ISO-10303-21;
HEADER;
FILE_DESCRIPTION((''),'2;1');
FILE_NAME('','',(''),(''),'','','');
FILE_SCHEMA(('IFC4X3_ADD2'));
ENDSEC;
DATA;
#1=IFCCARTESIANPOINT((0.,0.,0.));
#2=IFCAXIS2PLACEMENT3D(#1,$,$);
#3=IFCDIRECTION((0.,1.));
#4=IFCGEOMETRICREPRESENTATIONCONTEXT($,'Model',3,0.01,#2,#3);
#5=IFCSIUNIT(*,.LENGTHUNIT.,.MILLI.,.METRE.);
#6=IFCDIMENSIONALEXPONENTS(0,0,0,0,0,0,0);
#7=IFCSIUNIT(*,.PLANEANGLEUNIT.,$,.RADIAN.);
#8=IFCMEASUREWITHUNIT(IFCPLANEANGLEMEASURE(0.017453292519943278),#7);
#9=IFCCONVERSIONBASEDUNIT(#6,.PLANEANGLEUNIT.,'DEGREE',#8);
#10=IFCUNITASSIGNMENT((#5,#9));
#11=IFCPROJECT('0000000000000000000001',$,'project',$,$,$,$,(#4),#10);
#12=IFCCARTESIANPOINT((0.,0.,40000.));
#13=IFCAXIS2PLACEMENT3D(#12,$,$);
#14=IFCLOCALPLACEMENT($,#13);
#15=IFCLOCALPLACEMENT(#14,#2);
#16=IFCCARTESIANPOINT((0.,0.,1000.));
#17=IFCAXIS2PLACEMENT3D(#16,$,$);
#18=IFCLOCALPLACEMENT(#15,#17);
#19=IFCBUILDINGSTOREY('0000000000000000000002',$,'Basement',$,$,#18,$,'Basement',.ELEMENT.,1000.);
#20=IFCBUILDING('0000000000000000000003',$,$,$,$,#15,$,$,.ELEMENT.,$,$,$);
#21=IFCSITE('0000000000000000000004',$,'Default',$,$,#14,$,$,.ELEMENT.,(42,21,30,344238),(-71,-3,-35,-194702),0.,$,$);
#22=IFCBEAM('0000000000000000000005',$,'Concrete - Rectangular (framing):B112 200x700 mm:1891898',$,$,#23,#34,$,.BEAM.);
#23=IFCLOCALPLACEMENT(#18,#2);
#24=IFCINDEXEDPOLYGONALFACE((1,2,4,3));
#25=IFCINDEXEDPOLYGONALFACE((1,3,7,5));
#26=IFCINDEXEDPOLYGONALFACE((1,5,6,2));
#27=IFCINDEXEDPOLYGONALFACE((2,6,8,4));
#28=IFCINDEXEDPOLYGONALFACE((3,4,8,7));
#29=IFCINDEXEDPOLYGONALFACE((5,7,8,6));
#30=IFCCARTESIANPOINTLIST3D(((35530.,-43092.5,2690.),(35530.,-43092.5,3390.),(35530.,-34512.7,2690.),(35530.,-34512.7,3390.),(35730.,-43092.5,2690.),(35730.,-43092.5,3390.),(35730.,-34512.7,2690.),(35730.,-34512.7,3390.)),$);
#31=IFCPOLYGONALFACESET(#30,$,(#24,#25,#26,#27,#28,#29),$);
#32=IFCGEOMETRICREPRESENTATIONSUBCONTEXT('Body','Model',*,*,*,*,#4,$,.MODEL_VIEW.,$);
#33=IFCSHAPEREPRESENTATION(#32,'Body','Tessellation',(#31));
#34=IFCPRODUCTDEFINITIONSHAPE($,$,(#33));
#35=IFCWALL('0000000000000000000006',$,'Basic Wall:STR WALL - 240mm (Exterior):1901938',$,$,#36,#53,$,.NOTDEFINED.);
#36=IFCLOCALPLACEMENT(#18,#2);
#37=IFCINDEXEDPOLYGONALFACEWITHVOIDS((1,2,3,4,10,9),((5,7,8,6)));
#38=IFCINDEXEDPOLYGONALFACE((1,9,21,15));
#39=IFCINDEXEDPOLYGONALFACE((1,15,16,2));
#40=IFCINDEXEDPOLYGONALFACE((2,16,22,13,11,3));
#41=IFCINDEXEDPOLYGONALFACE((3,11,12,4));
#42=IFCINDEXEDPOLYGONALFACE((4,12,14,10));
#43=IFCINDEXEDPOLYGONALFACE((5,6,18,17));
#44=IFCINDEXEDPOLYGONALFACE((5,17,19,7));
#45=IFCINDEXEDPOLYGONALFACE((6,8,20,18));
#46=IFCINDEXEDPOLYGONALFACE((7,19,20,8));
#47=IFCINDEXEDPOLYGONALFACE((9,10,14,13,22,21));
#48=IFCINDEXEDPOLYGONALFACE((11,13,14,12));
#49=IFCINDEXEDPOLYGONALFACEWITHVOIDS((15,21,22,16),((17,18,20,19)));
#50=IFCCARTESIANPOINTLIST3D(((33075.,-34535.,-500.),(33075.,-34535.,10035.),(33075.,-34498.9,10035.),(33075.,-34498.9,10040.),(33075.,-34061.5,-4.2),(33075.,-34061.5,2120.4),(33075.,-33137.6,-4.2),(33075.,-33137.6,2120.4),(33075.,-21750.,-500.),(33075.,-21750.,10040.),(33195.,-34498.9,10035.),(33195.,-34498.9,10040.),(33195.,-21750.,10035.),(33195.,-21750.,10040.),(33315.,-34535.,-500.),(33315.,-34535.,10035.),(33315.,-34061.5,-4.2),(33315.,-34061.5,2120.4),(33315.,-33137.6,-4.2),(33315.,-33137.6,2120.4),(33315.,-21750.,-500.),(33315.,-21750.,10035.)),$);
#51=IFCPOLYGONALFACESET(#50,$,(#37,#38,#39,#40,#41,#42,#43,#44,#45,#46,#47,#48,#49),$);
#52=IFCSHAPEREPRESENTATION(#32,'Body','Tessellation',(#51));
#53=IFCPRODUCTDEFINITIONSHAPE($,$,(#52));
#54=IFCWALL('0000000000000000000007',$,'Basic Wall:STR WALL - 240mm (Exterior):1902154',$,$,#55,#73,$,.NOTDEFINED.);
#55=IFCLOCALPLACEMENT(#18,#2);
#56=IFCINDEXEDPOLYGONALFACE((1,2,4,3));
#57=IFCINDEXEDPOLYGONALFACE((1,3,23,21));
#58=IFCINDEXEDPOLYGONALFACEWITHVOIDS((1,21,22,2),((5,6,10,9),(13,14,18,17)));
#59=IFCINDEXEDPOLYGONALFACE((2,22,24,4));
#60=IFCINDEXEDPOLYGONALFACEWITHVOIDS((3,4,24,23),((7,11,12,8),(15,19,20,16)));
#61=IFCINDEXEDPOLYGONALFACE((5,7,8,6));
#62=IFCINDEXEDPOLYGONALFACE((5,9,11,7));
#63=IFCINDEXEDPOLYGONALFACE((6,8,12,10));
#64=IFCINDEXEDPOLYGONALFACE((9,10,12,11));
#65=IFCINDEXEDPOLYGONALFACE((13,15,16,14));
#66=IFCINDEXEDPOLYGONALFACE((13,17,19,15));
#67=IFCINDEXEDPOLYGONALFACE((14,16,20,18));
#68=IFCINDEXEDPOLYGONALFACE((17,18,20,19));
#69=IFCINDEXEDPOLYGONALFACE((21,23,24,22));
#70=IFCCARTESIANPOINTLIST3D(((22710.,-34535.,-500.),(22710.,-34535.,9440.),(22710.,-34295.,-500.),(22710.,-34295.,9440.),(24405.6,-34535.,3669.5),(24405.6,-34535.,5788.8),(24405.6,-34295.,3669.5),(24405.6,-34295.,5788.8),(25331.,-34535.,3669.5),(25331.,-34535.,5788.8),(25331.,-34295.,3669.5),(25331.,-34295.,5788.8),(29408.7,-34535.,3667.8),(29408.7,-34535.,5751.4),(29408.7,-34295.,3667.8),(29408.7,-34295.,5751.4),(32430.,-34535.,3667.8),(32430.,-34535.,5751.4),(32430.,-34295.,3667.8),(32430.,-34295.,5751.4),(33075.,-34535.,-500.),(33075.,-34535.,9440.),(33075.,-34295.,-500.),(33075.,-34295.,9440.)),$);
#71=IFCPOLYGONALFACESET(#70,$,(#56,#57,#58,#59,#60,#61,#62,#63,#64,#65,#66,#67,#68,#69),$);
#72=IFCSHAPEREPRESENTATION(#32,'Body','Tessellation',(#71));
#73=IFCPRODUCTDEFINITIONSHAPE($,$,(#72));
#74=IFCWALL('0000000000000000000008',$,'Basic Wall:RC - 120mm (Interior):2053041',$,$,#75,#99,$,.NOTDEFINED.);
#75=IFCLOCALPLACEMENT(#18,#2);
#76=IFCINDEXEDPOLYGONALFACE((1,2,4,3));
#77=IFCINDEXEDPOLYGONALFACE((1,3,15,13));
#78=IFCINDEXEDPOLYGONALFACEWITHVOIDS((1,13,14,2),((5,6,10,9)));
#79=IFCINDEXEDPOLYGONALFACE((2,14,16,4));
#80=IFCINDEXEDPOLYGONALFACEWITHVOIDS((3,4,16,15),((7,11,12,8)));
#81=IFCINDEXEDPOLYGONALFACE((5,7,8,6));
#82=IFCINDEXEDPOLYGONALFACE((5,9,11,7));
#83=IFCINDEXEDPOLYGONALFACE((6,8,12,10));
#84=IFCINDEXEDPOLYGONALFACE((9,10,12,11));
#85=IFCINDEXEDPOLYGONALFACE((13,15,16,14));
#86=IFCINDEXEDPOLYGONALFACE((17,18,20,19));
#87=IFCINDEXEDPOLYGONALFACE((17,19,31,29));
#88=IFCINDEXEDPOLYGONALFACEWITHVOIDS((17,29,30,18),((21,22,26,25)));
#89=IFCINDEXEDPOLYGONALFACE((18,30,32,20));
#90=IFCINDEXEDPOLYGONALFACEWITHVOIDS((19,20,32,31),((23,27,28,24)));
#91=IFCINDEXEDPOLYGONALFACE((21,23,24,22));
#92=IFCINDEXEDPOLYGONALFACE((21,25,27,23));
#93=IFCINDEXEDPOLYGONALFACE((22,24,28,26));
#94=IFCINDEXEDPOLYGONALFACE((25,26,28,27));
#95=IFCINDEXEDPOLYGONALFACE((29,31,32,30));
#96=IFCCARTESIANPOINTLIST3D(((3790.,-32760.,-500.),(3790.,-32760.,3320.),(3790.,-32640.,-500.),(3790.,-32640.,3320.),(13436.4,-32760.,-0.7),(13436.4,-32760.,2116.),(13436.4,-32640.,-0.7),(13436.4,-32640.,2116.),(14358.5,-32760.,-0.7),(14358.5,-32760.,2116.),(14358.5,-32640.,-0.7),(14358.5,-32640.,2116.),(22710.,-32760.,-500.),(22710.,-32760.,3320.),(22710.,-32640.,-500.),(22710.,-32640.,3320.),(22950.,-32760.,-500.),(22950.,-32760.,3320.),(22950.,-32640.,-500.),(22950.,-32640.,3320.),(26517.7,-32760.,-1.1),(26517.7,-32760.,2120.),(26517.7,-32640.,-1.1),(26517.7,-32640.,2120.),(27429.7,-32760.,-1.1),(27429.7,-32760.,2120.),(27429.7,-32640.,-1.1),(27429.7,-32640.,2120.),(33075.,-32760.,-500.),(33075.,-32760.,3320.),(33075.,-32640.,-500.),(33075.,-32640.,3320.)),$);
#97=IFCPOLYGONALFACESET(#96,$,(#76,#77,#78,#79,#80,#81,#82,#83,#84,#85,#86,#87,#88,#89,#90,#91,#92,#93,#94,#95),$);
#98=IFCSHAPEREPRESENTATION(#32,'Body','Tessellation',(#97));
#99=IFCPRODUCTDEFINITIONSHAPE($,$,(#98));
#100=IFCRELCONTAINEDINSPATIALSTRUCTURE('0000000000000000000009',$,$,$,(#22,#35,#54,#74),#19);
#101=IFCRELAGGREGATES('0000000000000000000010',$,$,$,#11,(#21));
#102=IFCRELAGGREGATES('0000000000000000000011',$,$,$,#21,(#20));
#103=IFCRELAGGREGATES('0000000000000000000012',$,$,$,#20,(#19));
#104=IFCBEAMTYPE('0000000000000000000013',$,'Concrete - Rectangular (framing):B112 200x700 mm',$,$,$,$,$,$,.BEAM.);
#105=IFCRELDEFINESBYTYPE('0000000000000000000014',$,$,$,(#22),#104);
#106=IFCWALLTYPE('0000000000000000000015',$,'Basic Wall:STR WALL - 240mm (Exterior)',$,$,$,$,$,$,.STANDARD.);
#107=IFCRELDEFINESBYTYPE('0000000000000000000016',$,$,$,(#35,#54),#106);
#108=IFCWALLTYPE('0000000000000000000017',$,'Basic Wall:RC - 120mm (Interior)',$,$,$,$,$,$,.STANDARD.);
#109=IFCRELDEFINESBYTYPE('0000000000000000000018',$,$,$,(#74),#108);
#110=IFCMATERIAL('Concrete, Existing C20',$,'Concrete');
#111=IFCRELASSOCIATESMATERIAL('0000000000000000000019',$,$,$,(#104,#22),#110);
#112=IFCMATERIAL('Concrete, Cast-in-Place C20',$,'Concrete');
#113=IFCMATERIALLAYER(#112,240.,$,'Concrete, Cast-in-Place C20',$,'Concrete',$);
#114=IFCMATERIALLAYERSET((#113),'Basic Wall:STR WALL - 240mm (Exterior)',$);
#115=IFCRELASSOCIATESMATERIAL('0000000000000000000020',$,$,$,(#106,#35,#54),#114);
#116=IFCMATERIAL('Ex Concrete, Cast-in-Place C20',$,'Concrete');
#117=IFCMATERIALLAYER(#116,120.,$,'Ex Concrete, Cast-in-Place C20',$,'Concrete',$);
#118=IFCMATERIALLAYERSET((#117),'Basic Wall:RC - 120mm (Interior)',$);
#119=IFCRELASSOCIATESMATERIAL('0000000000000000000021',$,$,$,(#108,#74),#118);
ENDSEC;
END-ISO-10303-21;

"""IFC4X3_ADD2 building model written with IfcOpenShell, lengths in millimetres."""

from ifc_helpers import new_model, entity, si_unit, converted_unit, direction, frame, frame_2d, origin, origin_2d_with_axis, place, context, subcontext, project, spatial, polyline, rectangle, extrude, clip, bounded_halfspace, source, transform, mapped, material, layer, layer_set, material_profile, profile_set, profile_usage, type_object, type_shapes, element, save


model = new_model("IFC4X3_ADD2")

# Units and contexts
model_context = context("Model", 3, precision=0.01, world=origin(), true_north=direction((0.0, 1.0)))
body_context = subcontext(model_context, "Body", "Model", "MODEL_VIEW")
ifc_project = project(units=[si_unit("LENGTHUNIT", "METRE", prefix="MILLI"), converted_unit("PLANEANGLEUNIT", "DEGREE", entity("IfcPlaneAngleMeasure", 0.017453292519943278), si_unit("PLANEANGLEUNIT", "RADIAN"), dimensions=[0, 0, 0, 0, 0, 0, 0])], contexts=[model_context])

# Site, building, storey
site_placement = place(None, frame((0.0, 0.0, 40000.0)))
site = spatial("IfcSite", under=ifc_project, at=site_placement, Name="Default", CompositionType="ELEMENT", RefLatitude=(42, 21, 30, 344238), RefLongitude=(-71, -3, -35, -194702), RefElevation=0.0)
building_placement = place(site_placement, origin())
building = spatial("IfcBuilding", under=site, at=building_placement, CompositionType="ELEMENT")
storey_placement = place(building_placement, frame((0.0, 0.0, 1000.0)))
storey = spatial("IfcBuildingStorey", under=building, at=storey_placement, Name="Basement", LongName="Basement", CompositionType="ELEMENT", Elevation=1000.0)

# Shared definitions
ifc_material_1 = material(Name="Concrete, Existing C20", Category="Concrete")

# Beam
ifc_material_profile_1 = material_profile(ifc_material_1, rectangle(XDim=8579.8, YDim=200.0, at=origin_2d_with_axis()), Name="B112 200x700 mm")
ifc_profile_set_1 = profile_set([ifc_material_profile_1], Name="B112 200x700 mm")
ifc_profile_usage_1 = profile_usage(ifc_profile_set_1, cardinal=8)
beam_type_1 = type_object("IfcBeamType", Name="Concrete - Rectangular (framing):B112 200x700 mm", PredefinedType="BEAM", material=ifc_profile_set_1)
shared_shape_1 = source(origin(), body_context, "Body", "SweptSolid", [
    extrude(rectangle(XDim=8579.8, YDim=200.0, at=origin_2d_with_axis()), frame((72.6, 0.0, -350.0), z_axis=(0.0, 0.0, 1.0), x_axis=(-1.0, 0.0, 0.0)), (0.0, 0.0, 1.0), 700.0),
])
type_shapes(beam_type_1, [shared_shape_1])
for number, where, z_axis, x_axis, name in (
    (1, (35630.0, -38730.0, 3040.0), (0.0, 0.0, 1.0), (0.0, -1.0, 0.0), "Concrete - Rectangular (framing):B112 200x700 mm:1891898"),
):
    element("IfcBeam", number, at=place(storey_placement, frame(where, z_axis=z_axis, x_axis=x_axis)), inside=storey, type_object=beam_type_1, material=ifc_profile_usage_1, Name=name, PredefinedType="BEAM", context=body_context, shape_type="MappedRepresentation", body=[
        mapped(shared_shape_1, transform((0.0, 0.0, 0.0), scale=1.0)),
    ])

# Wall, opening
ifc_material_2 = material(Name="Concrete, Cast-in-Place C20", Category="Concrete")
ifc_layer_1 = layer(ifc_material_2, 240.0, Name="Concrete, Cast-in-Place C20", Category="Concrete")
ifc_layer_set_1 = layer_set([ifc_layer_1], Name="Basic Wall:STR WALL - 240mm (Exterior)")
wall_type_1 = type_object("IfcWallType", Name="Basic Wall:STR WALL - 240mm (Exterior)", PredefinedType="STANDARD", material=ifc_layer_set_1)
wall_1_placement = place(storey_placement, frame((33195.0, -21750.0, -500.0), z_axis=(0.0, 0.0, 1.0), x_axis=(0.0, -1.0, 0.0)))
wall_1 = element("IfcWall", 2, at=wall_1_placement, inside=storey, type_object=wall_type_1, material=ifc_layer_set_1, Name="Basic Wall:STR WALL - 240mm (Exterior):1901938", PredefinedType="NOTDEFINED", context=body_context, shape_type="Clipping", body=[
    clip(clip(clip(clip(extrude(rectangle(XDim=12785.0, YDim=240.0, at=frame_2d((6392.5, 0.0), x_axis=(-1.0, 0.0))), origin(), (0.0, 0.0, 1.0), 10540.0), bounded_halfspace(frame((0.0, -120.0, 10540.0), z_axis=(0.0, 0.0, -1.0), x_axis=(1.0, 0.0, 0.0)), True, frame((0.0, -120.0, 10540.0)), polyline([(0.0, 0.0), (12748.9, 0.0), (12748.9, 120.0), (0.0, 120.0), (0.0, 0.0)]))), bounded_halfspace(frame((12748.9, -120.0, 10535.0), z_axis=(0.0, 0.0, 1.0), x_axis=(0.0, 1.0, 0.0)), False, frame((12748.9, -120.0, 10535.0)), polyline([(0.0, 0.0), (36.1, 0.0), (36.1, 120.0), (0.0, 120.0), (0.0, 0.0)]))), bounded_halfspace(frame((12748.9, 120.0, 10535.0), z_axis=(0.0, 0.0, 1.0), x_axis=(0.0, 1.0, 0.0)), False, frame((12748.9, 120.0, 10535.0)), polyline([(0.0, 0.0), (-12748.9, 0.0), (-12748.9, -120.0), (0.0, -120.0), (0.0, 0.0)]))), bounded_halfspace(frame((12785.0, 0.0, 10535.0), z_axis=(0.0, 0.0, 1.0), x_axis=(0.0, 1.0, 0.0)), False, frame((12785.0, 0.0, 10535.0)), polyline([(0.0, 0.0), (0.0, 120.0), (-36.1, 120.0), (-36.1, 0.0), (0.0, 0.0)]))),
])
opening_1_placement = place(wall_1_placement, frame((12311.5, -120.0, 495.8)))
element("IfcOpeningElement", 3, at=opening_1_placement, cuts=wall_1, PredefinedType="OPENING", context=body_context, shape_type="SweptSolid", body=[
    extrude(rectangle(XDim=2124.6, YDim=923.9, at=frame_2d((0.0, 0.0), x_axis=(1.0, 0.0))), frame((-461.9, 0.0, 1062.3), z_axis=(0.0, 1.0, 0.0), x_axis=(0.0, 0.0, -1.0)), (0.0, 0.0, 1.0), 240.0),
])

# Walls, openings
wall_2_placement = place(storey_placement, frame((33075.0, -34415.0, -500.0), z_axis=(0.0, 0.0, 1.0), x_axis=(-1.0, 0.0, 0.0)))
wall_2 = element("IfcWall", 4, at=wall_2_placement, inside=storey, type_object=wall_type_1, material=ifc_layer_set_1, Name="Basic Wall:STR WALL - 240mm (Exterior):1902154", PredefinedType="NOTDEFINED", context=body_context, shape_type="SweptSolid", body=[
    extrude(rectangle(XDim=10365.0, YDim=240.0, at=frame_2d((5182.5, 0.0), x_axis=(-1.0, 0.0))), origin(), (0.0, 0.0, 1.0), 9940.0),
])
opening_2_placement = place(wall_2_placement, frame((8669.4, 120.0, 4169.5)))
element("IfcOpeningElement", 5, at=opening_2_placement, cuts=wall_2, PredefinedType="OPENING", context=body_context, shape_type="SweptSolid", body=[
    extrude(rectangle(XDim=2119.3, YDim=925.4, at=origin_2d_with_axis()), frame((-462.7, -240.0, 1059.6), z_axis=(0.0, 1.0, 0.0), x_axis=(0.0, 0.0, -1.0)), (0.0, 0.0, 1.0), 240.0),
])
opening_3_placement = place(wall_2_placement, frame((3666.3, 120.0, 4167.8)))
element("IfcOpeningElement", 6, at=opening_3_placement, cuts=wall_2, PredefinedType="OPENING", context=body_context, shape_type="SweptSolid", body=[
    extrude(rectangle(XDim=2083.6, YDim=3021.3, at=frame_2d((0.0, 0.0), x_axis=(1.0, 0.0))), frame((-1510.7, -240.0, 1041.8), z_axis=(0.0, 1.0, 0.0), x_axis=(0.0, 0.0, -1.0)), (0.0, 0.0, 1.0), 240.0),
])
ifc_material_3 = material(Name="Ex Concrete, Cast-in-Place C20", Category="Concrete")
ifc_layer_2 = layer(ifc_material_3, 120.0, Name="Ex Concrete, Cast-in-Place C20", Category="Concrete")
ifc_layer_set_2 = layer_set([ifc_layer_2], Name="Basic Wall:RC - 120mm (Interior)")
wall_type_2 = type_object("IfcWallType", Name="Basic Wall:RC - 120mm (Interior)", PredefinedType="STANDARD", material=ifc_layer_set_2)
wall_3_placement = place(storey_placement, frame((33075.0, -32700.0, -500.0), z_axis=(0.0, 0.0, 1.0), x_axis=(-1.0, 0.0, 0.0)))
wall_3 = element("IfcWall", 7, at=wall_3_placement, inside=storey, type_object=wall_type_2, material=ifc_layer_set_2, Name="Basic Wall:RC - 120mm (Interior):2053041", PredefinedType="NOTDEFINED", context=body_context, shape_type="SweptSolid", body=[
    extrude(rectangle(XDim=120.0, YDim=29285.0, at=frame_2d((14642.5, 0.0), x_axis=(0.0, -1.0))), origin(), (0.0, 0.0, 1.0), 3820.0),
])
opening_4_placement = place(storey_placement, frame((33075.0, -32700.0, -500.0), z_axis=(0.0, 0.0, 1.0), x_axis=(-1.0, 0.0, 0.0)))
element("IfcOpeningElement", 8, at=opening_4_placement, cuts=wall_3, PredefinedType="OPENING", context=body_context, shape_type="SweptSolid", body=[
    extrude(rectangle(XDim=3820.0, YDim=120.0, at=frame_2d((0.0, 0.0), x_axis=(1.0, 0.0))), frame((10365.0, 0.0, 1910.0), z_axis=(-1.0, 0.0, 0.0), x_axis=(0.0, 0.0, 1.0)), (0.0, 0.0, 1.0), 240.0),
])
opening_5_placement = place(wall_3_placement, frame((19638.6, 60.0, 499.3)))
element("IfcOpeningElement", 9, at=opening_5_placement, cuts=wall_3, PredefinedType="OPENING", context=body_context, shape_type="SweptSolid", body=[
    extrude(rectangle(XDim=2116.7, YDim=922.0, at=frame_2d((0.0, 0.0), x_axis=(1.0, 0.0))), frame((-461.0, -120.0, 1058.4), z_axis=(0.0, 1.0, 0.0), x_axis=(0.0, 0.0, -1.0)), (0.0, 0.0, 1.0), 120.0),
])
opening_6_placement = place(wall_3_placement, frame((6557.3, 60.0, 498.9)))
element("IfcOpeningElement", 10, at=opening_6_placement, cuts=wall_3, PredefinedType="OPENING", context=body_context, shape_type="SweptSolid", body=[
    extrude(rectangle(XDim=2121.1, YDim=912.0, at=frame_2d((0.0, 0.0), x_axis=(1.0, 0.0))), frame((-456.0, -120.0, 1060.6), z_axis=(0.0, 1.0, 0.0), x_axis=(0.0, 0.0, -1.0)), (0.0, 0.0, 1.0), 120.0),
])

save(model, "model.ifc")
